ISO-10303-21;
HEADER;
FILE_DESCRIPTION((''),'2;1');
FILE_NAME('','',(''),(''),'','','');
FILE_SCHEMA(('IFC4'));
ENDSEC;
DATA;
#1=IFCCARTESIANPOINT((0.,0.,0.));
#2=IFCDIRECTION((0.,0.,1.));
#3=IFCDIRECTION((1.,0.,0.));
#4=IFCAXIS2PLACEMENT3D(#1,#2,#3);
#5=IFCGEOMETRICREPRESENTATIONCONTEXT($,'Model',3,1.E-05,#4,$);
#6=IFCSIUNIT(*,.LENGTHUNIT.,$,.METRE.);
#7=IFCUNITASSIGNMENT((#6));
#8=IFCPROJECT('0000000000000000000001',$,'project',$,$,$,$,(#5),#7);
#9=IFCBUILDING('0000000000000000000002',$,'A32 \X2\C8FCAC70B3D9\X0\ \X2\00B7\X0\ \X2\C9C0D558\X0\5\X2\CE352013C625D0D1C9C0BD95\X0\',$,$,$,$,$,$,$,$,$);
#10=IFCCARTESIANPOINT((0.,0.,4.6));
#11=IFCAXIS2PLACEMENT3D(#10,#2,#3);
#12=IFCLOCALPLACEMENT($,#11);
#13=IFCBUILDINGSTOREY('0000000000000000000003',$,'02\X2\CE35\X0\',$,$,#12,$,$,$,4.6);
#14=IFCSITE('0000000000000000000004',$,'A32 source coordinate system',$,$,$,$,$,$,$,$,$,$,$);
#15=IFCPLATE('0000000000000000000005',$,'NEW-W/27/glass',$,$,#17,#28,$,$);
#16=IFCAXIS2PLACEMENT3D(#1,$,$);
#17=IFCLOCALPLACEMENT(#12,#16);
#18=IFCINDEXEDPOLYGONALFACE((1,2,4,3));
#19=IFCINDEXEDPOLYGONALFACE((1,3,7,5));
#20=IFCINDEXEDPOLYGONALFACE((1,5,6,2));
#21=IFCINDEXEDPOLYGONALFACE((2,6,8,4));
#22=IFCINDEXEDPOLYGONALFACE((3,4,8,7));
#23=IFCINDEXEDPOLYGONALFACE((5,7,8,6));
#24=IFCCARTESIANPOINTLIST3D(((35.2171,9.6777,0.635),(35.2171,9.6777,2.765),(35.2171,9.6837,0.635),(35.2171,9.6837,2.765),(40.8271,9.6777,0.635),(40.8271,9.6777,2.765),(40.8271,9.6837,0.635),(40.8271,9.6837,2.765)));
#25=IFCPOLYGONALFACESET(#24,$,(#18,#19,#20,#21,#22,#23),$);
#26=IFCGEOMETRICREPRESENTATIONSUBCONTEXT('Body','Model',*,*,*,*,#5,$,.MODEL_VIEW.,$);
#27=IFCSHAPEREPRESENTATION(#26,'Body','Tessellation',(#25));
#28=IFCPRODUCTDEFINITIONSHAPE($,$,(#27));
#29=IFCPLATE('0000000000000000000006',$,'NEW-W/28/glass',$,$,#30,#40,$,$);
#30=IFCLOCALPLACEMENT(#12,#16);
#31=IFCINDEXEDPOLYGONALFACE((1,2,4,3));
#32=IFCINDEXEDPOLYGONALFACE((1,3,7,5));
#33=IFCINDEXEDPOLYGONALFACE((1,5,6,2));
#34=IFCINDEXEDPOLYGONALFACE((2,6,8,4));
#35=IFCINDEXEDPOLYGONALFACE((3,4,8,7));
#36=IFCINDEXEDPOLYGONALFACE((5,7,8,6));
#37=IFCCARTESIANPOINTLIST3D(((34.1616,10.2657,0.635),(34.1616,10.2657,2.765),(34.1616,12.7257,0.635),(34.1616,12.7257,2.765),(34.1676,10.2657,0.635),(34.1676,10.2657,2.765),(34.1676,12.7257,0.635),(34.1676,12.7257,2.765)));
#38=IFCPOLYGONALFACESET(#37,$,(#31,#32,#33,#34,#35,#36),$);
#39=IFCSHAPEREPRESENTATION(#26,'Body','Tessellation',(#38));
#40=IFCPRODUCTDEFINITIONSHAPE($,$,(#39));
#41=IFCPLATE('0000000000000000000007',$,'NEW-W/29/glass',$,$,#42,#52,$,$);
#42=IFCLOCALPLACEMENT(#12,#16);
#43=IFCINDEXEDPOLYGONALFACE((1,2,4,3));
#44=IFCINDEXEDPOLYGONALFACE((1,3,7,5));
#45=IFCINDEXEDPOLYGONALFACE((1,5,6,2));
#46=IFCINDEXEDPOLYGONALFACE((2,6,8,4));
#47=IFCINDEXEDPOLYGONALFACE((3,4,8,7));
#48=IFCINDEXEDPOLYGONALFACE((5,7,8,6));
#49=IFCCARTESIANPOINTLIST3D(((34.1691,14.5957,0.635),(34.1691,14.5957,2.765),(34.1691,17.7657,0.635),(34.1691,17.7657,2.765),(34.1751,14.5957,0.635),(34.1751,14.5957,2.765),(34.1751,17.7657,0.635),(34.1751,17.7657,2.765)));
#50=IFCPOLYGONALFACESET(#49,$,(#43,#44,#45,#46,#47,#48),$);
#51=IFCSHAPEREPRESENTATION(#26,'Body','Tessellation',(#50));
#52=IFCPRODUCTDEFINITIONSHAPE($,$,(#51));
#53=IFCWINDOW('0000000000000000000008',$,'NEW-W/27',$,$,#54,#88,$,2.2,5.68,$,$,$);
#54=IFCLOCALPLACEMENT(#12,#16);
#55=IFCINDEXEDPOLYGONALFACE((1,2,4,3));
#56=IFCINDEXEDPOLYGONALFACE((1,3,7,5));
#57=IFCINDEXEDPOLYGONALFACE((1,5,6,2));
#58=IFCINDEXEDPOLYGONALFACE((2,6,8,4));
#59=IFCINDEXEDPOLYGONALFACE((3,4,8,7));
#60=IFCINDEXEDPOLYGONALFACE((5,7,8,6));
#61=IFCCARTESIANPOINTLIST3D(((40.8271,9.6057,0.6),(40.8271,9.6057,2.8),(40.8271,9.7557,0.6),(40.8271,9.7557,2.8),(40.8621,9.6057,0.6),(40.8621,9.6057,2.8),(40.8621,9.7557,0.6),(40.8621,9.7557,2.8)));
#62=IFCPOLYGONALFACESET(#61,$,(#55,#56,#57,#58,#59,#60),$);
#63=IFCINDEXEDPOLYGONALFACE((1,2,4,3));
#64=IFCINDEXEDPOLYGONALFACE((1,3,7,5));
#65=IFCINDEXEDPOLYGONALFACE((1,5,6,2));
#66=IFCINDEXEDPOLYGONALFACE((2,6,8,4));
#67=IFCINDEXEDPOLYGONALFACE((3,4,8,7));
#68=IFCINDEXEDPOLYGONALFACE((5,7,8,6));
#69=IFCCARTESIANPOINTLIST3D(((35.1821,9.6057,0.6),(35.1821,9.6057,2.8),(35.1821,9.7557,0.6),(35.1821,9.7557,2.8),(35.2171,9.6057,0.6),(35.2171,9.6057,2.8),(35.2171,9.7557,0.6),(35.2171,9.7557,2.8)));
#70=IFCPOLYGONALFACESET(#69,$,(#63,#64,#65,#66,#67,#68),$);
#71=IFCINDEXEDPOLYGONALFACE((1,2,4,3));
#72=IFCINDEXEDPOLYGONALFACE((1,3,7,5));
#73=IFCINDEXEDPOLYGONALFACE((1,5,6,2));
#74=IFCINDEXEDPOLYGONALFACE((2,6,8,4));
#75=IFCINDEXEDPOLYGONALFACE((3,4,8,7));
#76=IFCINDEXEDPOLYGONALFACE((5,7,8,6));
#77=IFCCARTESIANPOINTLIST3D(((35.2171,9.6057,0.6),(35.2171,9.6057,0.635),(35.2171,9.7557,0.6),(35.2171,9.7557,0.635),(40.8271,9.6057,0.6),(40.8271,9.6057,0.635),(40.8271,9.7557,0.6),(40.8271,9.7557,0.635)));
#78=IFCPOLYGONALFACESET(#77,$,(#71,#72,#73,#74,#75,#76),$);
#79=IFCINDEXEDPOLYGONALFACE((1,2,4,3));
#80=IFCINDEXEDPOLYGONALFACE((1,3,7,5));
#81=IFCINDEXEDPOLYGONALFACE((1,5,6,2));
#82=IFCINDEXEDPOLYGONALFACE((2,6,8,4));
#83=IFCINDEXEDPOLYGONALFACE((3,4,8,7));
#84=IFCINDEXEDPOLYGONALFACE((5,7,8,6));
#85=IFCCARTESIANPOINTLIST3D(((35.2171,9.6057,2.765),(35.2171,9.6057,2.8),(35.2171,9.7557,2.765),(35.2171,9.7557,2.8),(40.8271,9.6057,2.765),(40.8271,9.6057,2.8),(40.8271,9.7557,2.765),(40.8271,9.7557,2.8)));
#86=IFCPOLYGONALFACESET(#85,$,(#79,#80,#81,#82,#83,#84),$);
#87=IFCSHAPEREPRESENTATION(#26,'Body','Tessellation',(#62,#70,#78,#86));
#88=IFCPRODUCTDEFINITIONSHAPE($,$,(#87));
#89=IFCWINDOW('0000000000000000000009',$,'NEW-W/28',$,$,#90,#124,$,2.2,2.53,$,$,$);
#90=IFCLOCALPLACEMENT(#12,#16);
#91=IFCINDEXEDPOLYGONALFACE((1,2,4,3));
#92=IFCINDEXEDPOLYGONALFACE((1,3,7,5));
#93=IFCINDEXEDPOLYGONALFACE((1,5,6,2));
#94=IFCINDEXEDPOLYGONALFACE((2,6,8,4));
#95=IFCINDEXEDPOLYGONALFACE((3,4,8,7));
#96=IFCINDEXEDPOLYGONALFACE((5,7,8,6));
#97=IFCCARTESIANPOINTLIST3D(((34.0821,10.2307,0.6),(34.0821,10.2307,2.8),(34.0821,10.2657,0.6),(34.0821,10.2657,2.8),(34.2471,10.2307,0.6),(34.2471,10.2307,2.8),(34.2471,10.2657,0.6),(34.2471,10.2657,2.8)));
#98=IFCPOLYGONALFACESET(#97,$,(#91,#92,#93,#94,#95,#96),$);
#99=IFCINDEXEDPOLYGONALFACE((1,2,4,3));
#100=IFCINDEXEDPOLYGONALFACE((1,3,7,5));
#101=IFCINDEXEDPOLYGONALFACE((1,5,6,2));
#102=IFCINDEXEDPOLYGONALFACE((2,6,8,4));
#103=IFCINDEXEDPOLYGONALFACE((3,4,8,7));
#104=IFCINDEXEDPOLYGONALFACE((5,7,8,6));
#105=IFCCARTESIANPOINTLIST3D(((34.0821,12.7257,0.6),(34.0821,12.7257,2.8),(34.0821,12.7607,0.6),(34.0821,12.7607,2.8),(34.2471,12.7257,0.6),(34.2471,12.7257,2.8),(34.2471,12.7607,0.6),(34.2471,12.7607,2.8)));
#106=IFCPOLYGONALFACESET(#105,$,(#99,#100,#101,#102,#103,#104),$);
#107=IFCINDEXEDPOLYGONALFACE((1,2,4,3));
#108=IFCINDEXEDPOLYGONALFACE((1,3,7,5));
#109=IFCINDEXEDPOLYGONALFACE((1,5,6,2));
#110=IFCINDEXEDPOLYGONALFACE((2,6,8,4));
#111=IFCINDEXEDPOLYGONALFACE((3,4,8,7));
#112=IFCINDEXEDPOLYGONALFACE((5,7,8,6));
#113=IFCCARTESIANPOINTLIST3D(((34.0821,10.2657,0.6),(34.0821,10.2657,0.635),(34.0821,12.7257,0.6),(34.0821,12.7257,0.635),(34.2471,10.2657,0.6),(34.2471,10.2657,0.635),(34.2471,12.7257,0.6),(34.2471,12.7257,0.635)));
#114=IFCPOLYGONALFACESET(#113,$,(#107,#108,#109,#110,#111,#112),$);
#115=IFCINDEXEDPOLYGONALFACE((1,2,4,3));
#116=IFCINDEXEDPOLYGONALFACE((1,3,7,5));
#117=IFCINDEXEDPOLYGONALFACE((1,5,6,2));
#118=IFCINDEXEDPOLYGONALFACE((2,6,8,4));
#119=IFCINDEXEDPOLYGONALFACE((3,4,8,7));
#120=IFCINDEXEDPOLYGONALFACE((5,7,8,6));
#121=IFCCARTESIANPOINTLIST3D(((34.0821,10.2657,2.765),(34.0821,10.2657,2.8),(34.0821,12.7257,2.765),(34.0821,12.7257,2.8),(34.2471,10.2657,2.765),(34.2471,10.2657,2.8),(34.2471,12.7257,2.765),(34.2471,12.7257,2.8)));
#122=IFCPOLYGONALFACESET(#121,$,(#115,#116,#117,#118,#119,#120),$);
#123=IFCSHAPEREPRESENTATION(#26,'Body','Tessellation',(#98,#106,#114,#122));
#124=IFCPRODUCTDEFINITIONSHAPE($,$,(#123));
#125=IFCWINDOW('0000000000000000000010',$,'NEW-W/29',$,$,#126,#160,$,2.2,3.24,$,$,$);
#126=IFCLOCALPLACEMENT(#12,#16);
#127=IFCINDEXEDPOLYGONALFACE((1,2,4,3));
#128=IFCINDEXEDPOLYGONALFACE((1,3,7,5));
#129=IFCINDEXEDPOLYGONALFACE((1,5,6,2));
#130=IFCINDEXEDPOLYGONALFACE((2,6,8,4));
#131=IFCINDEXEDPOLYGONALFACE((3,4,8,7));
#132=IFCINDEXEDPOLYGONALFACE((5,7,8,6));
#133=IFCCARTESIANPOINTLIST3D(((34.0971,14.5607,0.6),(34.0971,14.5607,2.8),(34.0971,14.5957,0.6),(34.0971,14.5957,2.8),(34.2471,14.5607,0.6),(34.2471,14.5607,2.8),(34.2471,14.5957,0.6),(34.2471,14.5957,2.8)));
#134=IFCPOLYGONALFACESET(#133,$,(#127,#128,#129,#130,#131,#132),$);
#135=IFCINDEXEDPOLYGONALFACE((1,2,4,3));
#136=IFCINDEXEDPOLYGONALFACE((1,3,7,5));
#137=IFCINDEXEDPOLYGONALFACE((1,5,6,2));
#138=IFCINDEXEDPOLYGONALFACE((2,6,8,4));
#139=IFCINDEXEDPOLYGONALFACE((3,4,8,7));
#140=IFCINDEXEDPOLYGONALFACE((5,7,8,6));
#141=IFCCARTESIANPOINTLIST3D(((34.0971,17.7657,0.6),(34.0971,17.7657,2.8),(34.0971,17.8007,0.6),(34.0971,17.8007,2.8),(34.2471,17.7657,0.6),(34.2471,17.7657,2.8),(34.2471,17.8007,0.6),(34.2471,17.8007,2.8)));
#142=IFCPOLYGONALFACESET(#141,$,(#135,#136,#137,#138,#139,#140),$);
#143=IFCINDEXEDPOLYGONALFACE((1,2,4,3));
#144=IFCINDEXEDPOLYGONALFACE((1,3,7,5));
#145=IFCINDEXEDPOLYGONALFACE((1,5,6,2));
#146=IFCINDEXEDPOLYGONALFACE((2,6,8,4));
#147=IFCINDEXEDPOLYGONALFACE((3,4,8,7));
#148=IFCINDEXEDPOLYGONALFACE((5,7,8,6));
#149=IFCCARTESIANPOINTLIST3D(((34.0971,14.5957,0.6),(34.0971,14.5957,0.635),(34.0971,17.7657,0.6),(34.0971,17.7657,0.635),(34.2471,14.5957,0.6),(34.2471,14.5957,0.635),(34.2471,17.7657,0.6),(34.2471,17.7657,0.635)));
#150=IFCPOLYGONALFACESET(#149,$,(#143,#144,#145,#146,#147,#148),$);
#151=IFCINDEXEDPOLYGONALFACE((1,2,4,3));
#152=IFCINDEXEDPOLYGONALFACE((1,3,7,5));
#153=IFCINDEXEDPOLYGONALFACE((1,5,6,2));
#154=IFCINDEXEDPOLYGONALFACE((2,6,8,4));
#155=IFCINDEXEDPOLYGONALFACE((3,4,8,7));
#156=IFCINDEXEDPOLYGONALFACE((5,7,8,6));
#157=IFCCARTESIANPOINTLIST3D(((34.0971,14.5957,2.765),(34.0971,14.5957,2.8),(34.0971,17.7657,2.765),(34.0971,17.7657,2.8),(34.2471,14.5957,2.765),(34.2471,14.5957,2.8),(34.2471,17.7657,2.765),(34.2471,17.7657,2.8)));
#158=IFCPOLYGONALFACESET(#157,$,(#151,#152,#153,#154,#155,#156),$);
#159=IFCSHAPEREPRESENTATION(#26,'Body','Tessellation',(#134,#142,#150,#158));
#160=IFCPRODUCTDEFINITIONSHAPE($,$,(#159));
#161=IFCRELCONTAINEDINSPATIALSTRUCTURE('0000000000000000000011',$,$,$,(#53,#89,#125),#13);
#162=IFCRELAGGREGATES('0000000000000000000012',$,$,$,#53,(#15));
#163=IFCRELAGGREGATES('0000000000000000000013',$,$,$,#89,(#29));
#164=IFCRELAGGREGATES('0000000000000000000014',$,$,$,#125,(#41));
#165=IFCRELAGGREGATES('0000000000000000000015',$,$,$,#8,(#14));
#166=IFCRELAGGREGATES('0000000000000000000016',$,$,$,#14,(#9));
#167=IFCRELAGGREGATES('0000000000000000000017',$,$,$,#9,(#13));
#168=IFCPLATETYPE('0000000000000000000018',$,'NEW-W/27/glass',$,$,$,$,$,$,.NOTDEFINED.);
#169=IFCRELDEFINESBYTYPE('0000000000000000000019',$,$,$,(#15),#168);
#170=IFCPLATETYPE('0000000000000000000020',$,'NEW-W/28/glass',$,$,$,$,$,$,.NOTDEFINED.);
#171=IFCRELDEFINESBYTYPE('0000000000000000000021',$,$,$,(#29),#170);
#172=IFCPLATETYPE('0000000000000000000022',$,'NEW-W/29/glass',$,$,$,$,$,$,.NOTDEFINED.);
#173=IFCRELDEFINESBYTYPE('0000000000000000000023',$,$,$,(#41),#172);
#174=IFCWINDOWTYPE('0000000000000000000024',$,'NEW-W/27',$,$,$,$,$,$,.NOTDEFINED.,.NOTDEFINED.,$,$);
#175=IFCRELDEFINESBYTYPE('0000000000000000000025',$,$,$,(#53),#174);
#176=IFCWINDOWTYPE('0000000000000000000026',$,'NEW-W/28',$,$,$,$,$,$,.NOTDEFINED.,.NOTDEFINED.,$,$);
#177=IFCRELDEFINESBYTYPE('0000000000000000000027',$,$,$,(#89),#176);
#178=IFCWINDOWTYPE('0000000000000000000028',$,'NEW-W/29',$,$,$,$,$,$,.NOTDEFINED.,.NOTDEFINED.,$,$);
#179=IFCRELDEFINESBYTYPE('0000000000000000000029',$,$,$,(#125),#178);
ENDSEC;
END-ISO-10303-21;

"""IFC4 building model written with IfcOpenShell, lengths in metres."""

from ifc_helpers import new_model, si_unit, frame, origin, origin_with_axes, place, context, subcontext, project, spatial, polyline, outline, extrude, source, transform, mapped, type_object, type_shapes, element, aggregate, save


model = new_model("IFC4")

# Units and contexts
model_context = context("Model", 3, precision=1e-05, world=origin_with_axes())
body_context = subcontext(model_context, "Body", "Model", "MODEL_VIEW")
ifc_project = project(units=[si_unit("LENGTHUNIT", "METRE")], contexts=[model_context])

# Plates
storey_placement = place(None, frame((0.0, 0.0, 4.6), z_axis=(0.0, 0.0, 1.0), x_axis=(1.0, 0.0, 0.0)))
plate_type_1 = type_object("IfcPlateType", Name="NEW-W/27/glass", PredefinedType="NOTDEFINED")
shared_shape_1 = source(origin(), body_context, "Body", "SweptSolid", [
    extrude(outline(polyline([(40.8271, 9.6777), (35.2171, 9.6777), (35.2171, 9.6837), (40.8271, 9.6837), (40.8271, 9.6777)])), frame((0.0, 0.0, 0.635)), (0.0, 0.0, 1.0), 2.13),
])
type_shapes(plate_type_1, [shared_shape_1])
window_1_placement = place(storey_placement, origin_with_axes())
plate_1_placement = place(window_1_placement, origin_with_axes())
plate_1 = element("IfcPlate", 1, at=plate_1_placement, type_object=plate_type_1, Name="NEW-W/27/glass", context=body_context, shape_type="MappedRepresentation", body=[
    mapped(shared_shape_1, transform((0.0, 0.0, 0.0), scale=1.0)),
])
plate_type_2 = type_object("IfcPlateType", Name="NEW-W/28/glass", PredefinedType="NOTDEFINED")
shared_shape_2 = source(origin(), body_context, "Body", "SweptSolid", [
    extrude(outline(polyline([(34.1676, 10.2657), (34.1616, 10.2657), (34.1616, 12.7257), (34.1676, 12.7257), (34.1676, 10.2657)])), frame((0.0, 0.0, 0.635)), (0.0, 0.0, 1.0), 2.13),
])
type_shapes(plate_type_2, [shared_shape_2])
window_2_placement = place(storey_placement, origin_with_axes())
plate_2_placement = place(window_2_placement, origin_with_axes())
plate_2 = element("IfcPlate", 2, at=plate_2_placement, type_object=plate_type_2, Name="NEW-W/28/glass", context=body_context, shape_type="MappedRepresentation", body=[
    mapped(shared_shape_2, transform((0.0, 0.0, 0.0), scale=1.0)),
])
plate_type_3 = type_object("IfcPlateType", Name="NEW-W/29/glass", PredefinedType="NOTDEFINED")
shared_shape_3 = source(origin(), body_context, "Body", "SweptSolid", [
    extrude(outline(polyline([(34.1751, 14.5957), (34.1691, 14.5957), (34.1691, 17.7657), (34.1751, 17.7657), (34.1751, 14.5957)])), frame((0.0, 0.0, 0.635)), (0.0, 0.0, 1.0), 2.13),
])
type_shapes(plate_type_3, [shared_shape_3])
window_3_placement = place(storey_placement, origin_with_axes())
plate_3_placement = place(window_3_placement, origin_with_axes())
plate_3 = element("IfcPlate", 3, at=plate_3_placement, type_object=plate_type_3, Name="NEW-W/29/glass", context=body_context, shape_type="MappedRepresentation", body=[
    mapped(shared_shape_3, transform((0.0, 0.0, 0.0), scale=1.0)),
])

# Site, building, storey
site = spatial("IfcSite", under=ifc_project, Name="A32 source coordinate system")
building = spatial("IfcBuilding", under=site, Name="A32 주거동 · 지하5층–옥탑지붕")
storey = spatial("IfcBuildingStorey", under=building, at=storey_placement, Name="02층", Elevation=4.6)

# Windows
window_type_1 = type_object("IfcWindowType", Name="NEW-W/27", PartitioningType="NOTDEFINED", PredefinedType="NOTDEFINED")
shared_shape_4 = source(origin(), body_context, "Body", "SweptSolid", [
    extrude(outline(polyline([(40.8271, 9.6057), (40.8271, 9.7557), (40.8621, 9.7557), (40.8621, 9.6057), (40.8271, 9.6057)])), frame((0.0, 0.0, 0.6)), (0.0, 0.0, 1.0), 2.2),
    extrude(outline(polyline([(35.1821, 9.6057), (35.1821, 9.7557), (35.2171, 9.7557), (35.2171, 9.6057), (35.1821, 9.6057)])), frame((0.0, 0.0, 0.6)), (0.0, 0.0, 1.0), 2.2),
    extrude(outline(polyline([(40.8271, 9.6057), (40.8271, 9.7557), (35.2171, 9.7557), (35.2171, 9.6057), (40.8271, 9.6057)])), frame((0.0, 0.0, 0.6)), (0.0, 0.0, 1.0), 0.035),
    extrude(outline(polyline([(40.8271, 9.6057), (40.8271, 9.7557), (35.2171, 9.7557), (35.2171, 9.6057), (40.8271, 9.6057)])), frame((0.0, 0.0, 2.765)), (0.0, 0.0, 1.0), 0.035),
])
type_shapes(window_type_1, [shared_shape_4])
window_1 = element("IfcWindow", 4, at=window_1_placement, inside=storey, type_object=window_type_1, Name="NEW-W/27", OverallHeight=2.2, OverallWidth=5.68, context=body_context, shape_type="MappedRepresentation", body=[
    mapped(shared_shape_4, transform((0.0, 0.0, 0.0), scale=1.0)),
])
aggregate(window_1, [plate_1])
window_type_2 = type_object("IfcWindowType", Name="NEW-W/28", PartitioningType="NOTDEFINED", PredefinedType="NOTDEFINED")
shared_shape_5 = source(origin(), body_context, "Body", "SweptSolid", [
    extrude(outline(polyline([(34.0821, 10.2307), (34.0821, 10.2657), (34.2471, 10.2657), (34.2471, 10.2307), (34.0821, 10.2307)])), frame((0.0, 0.0, 0.6)), (0.0, 0.0, 1.0), 2.2),
    extrude(outline(polyline([(34.0821, 12.7257), (34.0821, 12.7607), (34.2471, 12.7607), (34.2471, 12.7257), (34.0821, 12.7257)])), frame((0.0, 0.0, 0.6)), (0.0, 0.0, 1.0), 2.2),
    extrude(outline(polyline([(34.2471, 10.2657), (34.2471, 12.7257), (34.0821, 12.7257), (34.0821, 10.2657), (34.2471, 10.2657)])), frame((0.0, 0.0, 0.6)), (0.0, 0.0, 1.0), 0.035),
    extrude(outline(polyline([(34.2471, 10.2657), (34.2471, 12.7257), (34.0821, 12.7257), (34.0821, 10.2657), (34.2471, 10.2657)])), frame((0.0, 0.0, 2.765)), (0.0, 0.0, 1.0), 0.035),
])
type_shapes(window_type_2, [shared_shape_5])
window_2 = element("IfcWindow", 5, at=window_2_placement, inside=storey, type_object=window_type_2, Name="NEW-W/28", OverallHeight=2.2, OverallWidth=2.53, context=body_context, shape_type="MappedRepresentation", body=[
    mapped(shared_shape_5, transform((0.0, 0.0, 0.0), scale=1.0)),
])
aggregate(window_2, [plate_2])
window_type_3 = type_object("IfcWindowType", Name="NEW-W/29", PartitioningType="NOTDEFINED", PredefinedType="NOTDEFINED")
shared_shape_6 = source(origin(), body_context, "Body", "SweptSolid", [
    extrude(outline(polyline([(34.0971, 14.5607), (34.0971, 14.5957), (34.2471, 14.5957), (34.2471, 14.5607), (34.0971, 14.5607)])), frame((0.0, 0.0, 0.6)), (0.0, 0.0, 1.0), 2.2),
    extrude(outline(polyline([(34.0971, 17.7657), (34.0971, 17.8007), (34.2471, 17.8007), (34.2471, 17.7657), (34.0971, 17.7657)])), frame((0.0, 0.0, 0.6)), (0.0, 0.0, 1.0), 2.2),
    extrude(outline(polyline([(34.2471, 14.5957), (34.2471, 17.7657), (34.0971, 17.7657), (34.0971, 14.5957), (34.2471, 14.5957)])), frame((0.0, 0.0, 0.6)), (0.0, 0.0, 1.0), 0.035),
    extrude(outline(polyline([(34.2471, 14.5957), (34.2471, 17.7657), (34.0971, 17.7657), (34.0971, 14.5957), (34.2471, 14.5957)])), frame((0.0, 0.0, 2.765)), (0.0, 0.0, 1.0), 0.035),
])
type_shapes(window_type_3, [shared_shape_6])
window_3 = element("IfcWindow", 6, at=window_3_placement, inside=storey, type_object=window_type_3, Name="NEW-W/29", OverallHeight=2.2, OverallWidth=3.24, context=body_context, shape_type="MappedRepresentation", body=[
    mapped(shared_shape_6, transform((0.0, 0.0, 0.0), scale=1.0)),
])
aggregate(window_3, [plate_3])

save(model, "model.ifc")
